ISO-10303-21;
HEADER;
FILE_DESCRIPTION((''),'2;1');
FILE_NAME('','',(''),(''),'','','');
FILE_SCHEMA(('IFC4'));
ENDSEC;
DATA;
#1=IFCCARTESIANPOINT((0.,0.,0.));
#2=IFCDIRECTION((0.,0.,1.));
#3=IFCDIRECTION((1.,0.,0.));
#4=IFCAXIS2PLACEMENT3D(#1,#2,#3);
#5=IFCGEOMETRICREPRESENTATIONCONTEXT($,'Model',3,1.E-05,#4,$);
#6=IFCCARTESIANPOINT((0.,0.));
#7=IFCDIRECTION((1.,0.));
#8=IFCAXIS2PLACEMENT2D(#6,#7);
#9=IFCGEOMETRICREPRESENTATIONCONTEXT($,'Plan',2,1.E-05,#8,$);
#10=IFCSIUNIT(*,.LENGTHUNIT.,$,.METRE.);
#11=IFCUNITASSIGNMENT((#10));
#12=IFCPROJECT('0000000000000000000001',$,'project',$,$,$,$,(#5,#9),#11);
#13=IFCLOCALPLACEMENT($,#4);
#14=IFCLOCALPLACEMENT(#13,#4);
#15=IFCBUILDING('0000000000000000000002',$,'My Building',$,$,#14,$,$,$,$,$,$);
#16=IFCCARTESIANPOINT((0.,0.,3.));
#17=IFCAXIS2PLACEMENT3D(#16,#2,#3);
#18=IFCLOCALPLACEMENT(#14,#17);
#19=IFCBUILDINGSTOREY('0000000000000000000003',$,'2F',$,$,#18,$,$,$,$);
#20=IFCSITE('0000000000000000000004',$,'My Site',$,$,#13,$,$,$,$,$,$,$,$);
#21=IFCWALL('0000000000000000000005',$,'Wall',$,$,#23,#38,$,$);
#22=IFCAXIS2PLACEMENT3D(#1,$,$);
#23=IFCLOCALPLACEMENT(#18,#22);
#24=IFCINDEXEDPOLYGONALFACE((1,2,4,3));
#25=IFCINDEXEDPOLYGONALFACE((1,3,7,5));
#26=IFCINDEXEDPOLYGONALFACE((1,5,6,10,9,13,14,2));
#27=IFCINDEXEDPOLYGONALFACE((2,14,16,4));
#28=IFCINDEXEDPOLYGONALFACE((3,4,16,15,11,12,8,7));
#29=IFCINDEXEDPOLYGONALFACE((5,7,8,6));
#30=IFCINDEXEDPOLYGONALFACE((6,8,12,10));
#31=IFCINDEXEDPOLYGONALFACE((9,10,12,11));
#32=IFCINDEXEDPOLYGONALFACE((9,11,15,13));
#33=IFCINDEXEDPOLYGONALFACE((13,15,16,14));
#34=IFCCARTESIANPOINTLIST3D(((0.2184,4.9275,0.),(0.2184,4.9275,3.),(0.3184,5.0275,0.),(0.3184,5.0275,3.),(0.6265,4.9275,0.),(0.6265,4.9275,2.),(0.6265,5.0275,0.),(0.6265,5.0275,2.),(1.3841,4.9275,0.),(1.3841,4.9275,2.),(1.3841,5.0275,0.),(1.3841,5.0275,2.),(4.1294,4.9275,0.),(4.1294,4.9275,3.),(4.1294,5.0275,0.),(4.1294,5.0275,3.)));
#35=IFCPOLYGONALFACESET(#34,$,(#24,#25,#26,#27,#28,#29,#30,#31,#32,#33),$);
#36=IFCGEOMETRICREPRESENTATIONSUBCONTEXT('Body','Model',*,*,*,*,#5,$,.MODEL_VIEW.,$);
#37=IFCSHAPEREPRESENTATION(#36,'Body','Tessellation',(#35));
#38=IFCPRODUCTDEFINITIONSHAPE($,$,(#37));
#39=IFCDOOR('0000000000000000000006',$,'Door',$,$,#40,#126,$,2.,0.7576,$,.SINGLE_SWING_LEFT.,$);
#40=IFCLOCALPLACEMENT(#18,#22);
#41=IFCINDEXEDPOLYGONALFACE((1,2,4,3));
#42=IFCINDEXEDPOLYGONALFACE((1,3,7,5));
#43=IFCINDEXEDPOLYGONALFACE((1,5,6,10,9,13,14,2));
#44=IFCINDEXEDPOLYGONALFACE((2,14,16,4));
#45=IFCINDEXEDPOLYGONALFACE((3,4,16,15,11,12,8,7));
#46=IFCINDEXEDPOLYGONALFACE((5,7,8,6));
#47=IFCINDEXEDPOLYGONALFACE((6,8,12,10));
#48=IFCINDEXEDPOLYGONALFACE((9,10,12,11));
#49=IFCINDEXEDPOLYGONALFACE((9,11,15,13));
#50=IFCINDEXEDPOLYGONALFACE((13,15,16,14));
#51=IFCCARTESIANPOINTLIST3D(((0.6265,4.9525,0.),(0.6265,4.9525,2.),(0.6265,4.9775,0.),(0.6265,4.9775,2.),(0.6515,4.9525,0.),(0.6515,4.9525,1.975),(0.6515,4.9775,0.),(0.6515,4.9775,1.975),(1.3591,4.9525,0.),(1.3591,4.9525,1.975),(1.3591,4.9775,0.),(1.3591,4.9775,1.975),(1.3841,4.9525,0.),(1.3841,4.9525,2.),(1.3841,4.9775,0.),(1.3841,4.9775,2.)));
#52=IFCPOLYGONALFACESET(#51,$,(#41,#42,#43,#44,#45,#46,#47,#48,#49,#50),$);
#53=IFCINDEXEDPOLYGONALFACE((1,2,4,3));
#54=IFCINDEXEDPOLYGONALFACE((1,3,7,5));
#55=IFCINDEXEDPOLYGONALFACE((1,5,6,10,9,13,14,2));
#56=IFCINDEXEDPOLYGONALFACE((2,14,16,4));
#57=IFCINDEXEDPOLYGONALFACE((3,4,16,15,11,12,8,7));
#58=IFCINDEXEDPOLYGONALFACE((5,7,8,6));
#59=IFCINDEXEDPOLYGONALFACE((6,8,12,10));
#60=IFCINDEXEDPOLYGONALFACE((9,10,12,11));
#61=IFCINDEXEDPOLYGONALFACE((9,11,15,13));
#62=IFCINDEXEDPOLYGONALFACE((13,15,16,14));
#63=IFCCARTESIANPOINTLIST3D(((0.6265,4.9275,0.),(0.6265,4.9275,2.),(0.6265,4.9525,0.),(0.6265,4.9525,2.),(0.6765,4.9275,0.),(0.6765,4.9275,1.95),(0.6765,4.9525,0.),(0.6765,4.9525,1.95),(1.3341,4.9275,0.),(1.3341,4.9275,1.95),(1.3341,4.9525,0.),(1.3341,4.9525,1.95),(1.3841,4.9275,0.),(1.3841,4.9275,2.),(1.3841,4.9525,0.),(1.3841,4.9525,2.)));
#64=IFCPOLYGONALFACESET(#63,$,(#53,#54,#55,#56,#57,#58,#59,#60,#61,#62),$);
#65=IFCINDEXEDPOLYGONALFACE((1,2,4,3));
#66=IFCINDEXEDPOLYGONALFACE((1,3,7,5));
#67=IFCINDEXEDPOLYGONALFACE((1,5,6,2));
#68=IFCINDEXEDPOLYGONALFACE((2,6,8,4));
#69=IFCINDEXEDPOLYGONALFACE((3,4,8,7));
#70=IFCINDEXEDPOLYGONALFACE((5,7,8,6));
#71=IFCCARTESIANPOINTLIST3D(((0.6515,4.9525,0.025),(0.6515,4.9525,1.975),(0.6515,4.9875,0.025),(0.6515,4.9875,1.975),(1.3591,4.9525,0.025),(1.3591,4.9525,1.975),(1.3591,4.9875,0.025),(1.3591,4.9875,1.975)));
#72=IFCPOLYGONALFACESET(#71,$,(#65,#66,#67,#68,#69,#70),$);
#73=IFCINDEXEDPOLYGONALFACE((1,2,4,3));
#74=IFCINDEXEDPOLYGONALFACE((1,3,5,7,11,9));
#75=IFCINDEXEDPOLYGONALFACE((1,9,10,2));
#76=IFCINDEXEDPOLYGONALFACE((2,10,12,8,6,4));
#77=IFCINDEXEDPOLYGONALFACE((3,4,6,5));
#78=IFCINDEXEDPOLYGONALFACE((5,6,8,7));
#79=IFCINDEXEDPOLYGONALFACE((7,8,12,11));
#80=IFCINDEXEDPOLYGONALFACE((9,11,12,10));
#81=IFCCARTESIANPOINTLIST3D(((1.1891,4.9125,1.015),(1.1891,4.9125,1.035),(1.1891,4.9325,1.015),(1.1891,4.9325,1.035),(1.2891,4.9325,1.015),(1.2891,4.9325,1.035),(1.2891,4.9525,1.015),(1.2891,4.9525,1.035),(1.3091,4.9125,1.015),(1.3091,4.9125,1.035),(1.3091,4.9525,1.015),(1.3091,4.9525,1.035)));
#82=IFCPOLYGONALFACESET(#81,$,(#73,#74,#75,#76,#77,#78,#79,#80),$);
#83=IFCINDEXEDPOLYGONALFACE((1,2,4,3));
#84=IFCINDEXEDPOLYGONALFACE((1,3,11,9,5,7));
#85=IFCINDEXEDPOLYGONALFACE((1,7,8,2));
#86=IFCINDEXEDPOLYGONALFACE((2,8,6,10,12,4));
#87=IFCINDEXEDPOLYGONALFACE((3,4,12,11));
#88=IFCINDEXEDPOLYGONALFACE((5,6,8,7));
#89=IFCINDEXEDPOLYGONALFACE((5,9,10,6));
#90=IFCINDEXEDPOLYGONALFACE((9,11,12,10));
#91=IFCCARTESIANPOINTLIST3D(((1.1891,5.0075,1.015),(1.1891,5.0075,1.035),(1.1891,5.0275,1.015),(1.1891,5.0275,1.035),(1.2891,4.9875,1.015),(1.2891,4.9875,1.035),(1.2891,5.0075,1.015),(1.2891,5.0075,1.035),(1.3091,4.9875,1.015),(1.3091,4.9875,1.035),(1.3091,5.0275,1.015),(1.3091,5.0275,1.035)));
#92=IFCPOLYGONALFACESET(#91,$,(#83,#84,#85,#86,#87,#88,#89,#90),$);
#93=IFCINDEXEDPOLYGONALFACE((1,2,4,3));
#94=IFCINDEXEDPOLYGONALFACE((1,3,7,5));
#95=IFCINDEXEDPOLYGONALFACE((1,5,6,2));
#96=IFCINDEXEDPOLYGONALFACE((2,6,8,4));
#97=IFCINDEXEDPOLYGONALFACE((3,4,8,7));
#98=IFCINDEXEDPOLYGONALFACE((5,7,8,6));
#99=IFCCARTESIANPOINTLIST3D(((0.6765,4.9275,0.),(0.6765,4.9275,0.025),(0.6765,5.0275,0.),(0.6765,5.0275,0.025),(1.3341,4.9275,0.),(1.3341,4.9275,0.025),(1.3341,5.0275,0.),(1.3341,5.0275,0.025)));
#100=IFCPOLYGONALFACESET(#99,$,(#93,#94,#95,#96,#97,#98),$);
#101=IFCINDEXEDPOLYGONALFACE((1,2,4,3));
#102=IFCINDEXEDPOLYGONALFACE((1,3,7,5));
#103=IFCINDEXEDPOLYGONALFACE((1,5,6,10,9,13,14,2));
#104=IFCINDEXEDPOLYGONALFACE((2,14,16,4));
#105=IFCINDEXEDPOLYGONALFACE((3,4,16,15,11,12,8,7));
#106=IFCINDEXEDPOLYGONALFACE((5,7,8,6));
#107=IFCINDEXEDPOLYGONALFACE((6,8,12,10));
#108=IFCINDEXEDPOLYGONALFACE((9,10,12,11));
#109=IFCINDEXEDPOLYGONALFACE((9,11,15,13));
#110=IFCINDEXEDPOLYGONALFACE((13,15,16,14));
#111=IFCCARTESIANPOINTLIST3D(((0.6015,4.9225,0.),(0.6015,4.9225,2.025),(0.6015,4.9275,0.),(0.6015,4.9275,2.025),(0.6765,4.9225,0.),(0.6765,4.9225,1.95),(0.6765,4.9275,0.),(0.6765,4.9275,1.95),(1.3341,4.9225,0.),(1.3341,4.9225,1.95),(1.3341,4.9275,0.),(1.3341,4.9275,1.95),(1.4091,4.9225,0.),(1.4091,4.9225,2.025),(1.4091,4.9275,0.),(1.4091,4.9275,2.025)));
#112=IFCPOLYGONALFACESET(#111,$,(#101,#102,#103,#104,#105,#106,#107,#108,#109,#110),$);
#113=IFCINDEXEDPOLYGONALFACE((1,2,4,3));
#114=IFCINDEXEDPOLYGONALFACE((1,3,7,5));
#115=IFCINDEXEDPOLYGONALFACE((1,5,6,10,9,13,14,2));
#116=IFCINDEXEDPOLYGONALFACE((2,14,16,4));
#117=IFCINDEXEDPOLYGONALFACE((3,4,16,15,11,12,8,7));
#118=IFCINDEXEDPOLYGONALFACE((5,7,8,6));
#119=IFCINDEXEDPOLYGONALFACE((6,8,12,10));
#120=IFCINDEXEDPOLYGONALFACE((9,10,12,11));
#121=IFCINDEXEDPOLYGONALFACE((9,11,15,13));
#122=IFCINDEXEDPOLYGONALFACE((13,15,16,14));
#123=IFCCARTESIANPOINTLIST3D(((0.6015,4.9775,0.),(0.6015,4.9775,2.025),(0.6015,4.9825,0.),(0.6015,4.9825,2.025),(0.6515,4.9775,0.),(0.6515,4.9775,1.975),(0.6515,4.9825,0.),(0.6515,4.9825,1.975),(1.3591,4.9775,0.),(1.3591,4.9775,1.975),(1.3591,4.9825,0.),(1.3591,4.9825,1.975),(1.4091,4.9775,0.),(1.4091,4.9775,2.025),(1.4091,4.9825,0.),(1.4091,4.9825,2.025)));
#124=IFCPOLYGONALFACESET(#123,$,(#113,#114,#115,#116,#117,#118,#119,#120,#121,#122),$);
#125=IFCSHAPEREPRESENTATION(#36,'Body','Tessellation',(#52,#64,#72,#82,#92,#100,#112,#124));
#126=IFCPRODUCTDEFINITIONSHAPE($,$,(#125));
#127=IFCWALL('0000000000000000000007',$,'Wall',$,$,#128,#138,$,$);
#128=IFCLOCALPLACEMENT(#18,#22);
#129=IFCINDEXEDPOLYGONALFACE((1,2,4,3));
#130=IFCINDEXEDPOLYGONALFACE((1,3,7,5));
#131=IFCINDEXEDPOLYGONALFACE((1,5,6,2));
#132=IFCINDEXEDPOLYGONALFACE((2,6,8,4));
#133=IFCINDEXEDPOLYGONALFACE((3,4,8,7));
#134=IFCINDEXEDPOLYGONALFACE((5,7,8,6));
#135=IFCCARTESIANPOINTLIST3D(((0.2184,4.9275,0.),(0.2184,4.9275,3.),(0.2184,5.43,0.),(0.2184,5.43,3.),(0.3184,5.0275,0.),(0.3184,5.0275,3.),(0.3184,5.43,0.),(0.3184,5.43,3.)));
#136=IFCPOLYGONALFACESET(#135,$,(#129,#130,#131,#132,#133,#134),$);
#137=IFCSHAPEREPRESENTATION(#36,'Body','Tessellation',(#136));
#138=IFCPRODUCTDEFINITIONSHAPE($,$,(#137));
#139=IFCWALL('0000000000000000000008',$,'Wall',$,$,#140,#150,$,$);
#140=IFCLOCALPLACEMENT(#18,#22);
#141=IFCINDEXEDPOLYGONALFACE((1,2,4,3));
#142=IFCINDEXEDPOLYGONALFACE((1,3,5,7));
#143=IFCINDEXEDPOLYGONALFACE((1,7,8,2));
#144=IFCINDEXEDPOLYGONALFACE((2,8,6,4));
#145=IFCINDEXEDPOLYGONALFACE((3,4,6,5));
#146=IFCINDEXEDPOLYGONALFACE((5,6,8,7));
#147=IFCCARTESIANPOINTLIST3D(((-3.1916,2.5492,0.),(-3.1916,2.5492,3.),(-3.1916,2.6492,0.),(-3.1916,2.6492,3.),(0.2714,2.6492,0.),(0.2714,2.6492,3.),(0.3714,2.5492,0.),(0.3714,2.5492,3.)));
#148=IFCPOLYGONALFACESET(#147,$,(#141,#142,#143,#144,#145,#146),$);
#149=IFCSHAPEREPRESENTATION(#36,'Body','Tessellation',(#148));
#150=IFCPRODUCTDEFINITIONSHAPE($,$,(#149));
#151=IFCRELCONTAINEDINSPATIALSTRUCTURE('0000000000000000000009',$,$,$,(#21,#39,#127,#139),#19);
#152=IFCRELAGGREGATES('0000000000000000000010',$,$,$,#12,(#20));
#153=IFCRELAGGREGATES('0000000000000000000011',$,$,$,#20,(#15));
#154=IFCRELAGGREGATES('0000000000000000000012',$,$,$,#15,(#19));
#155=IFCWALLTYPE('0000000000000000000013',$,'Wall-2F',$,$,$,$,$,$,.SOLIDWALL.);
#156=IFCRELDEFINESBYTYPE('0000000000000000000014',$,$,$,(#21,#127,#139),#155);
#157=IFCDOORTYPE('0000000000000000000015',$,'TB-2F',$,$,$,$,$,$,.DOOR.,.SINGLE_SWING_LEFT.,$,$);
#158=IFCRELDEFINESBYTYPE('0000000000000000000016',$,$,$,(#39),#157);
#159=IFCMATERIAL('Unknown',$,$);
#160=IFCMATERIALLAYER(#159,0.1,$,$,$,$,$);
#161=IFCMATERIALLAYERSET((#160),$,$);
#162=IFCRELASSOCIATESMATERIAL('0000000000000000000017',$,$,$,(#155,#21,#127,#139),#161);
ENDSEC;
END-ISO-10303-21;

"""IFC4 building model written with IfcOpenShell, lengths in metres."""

from ifc_helpers import new_model, entity, si_unit, frame, origin_with_axes, origin_2d_with_axis, place, context, subcontext, project, spatial, line, indexed_curve, outline, extrude, shape, source, transform, mapped, material, layer, layer_set, layer_usage, type_object, type_shapes, element, fill, save


model = new_model("IFC4")

# Units and contexts
model_context = context("Model", 3, precision=1e-05, world=origin_with_axes())
plan_context = context("Plan", 2, precision=1e-05, world=origin_2d_with_axis())
body_context_1 = subcontext(model_context, "Body", "Model", "MODEL_VIEW")
body_context_2 = subcontext(plan_context, "Body", "Plan", "PLAN_VIEW")
ifc_project = project(units=[si_unit("LENGTHUNIT", "METRE")], contexts=[model_context, plan_context])

# Site, building, storey
site_placement = place(None, origin_with_axes())
site = spatial("IfcSite", under=ifc_project, at=site_placement, Name="My Site")
building_placement = place(site_placement, origin_with_axes())
building = spatial("IfcBuilding", under=site, at=building_placement, Name="My Building")
storey_placement = place(building_placement, frame((0.0, 0.0, 3.0), z_axis=(0.0, 0.0, 1.0), x_axis=(1.0, 0.0, 0.0)))
storey = spatial("IfcBuildingStorey", under=building, at=storey_placement, Name="2F")

# Shared definitions
ifc_material = material(Name="Unknown")

# Shared definitions
ifc_layer_1 = layer(ifc_material, 0.1)
ifc_layer_set_1 = layer_set([ifc_layer_1])
wall_type = type_object("IfcWallType", Name="Wall-2F", PredefinedType="SOLIDWALL", material=ifc_layer_set_1)

# Wall, opening, door
ifc_layer_usage_1 = layer_usage(ifc_layer_set_1, "AXIS2", "POSITIVE", 0.0)
wall_1_placement = place(storey_placement, frame((4.2294, 5.0275, 0.0), z_axis=(0.0, 0.0, 1.0), x_axis=(-1.0, 0.0, 0.0)))
wall_1 = element("IfcWall", 1, at=wall_1_placement, inside=storey, type_object=wall_type, material=ifc_layer_usage_1, Name="Wall", context=body_context_1, shape_type="SweptSolid", body=[
    extrude(outline(indexed_curve([(0.1, 0.0), (0.1, 0.1), (4.0111, 0.1), (3.9111, 0.0)], segments=[line(1, 2, 3, 4, 1)])), origin_with_axes(), (0.0, 0.0, 1.0), 3.0),
])
shared_shape_1 = source(origin_with_axes(), body_context_1, "Body", "SweptSolid", [
    extrude(outline(indexed_curve([(0.0, 0.0), (0.7576, 0.0), (0.7576, 2.0), (0.0, 2.0)], segments=[line(1, 2, 3, 4, 1)])), frame((0.0, -0.6, 0.0), z_axis=(0.0, -1.0, 0.0), x_axis=(1.0, 0.0, 0.0)), (0.0, 0.0, -1.0), 1.2),
])
opening_1_placement = place(wall_1_placement, frame((3.6029, 0.1, 0.0), z_axis=(0.0, 0.0, 1.0), x_axis=(-1.0, 0.0, 0.0)))
opening_1 = element("IfcOpeningElement", 2, at=opening_1_placement, cuts=wall_1, PredefinedType="OPENING", context=body_context_1, shape_type="MappedRepresentation", body=[
    mapped(shared_shape_1, transform((0.0, 0.0, 0.0), x_axis=(1.0, 0.0, 0.0), y_axis=(0.0, 1.0, 0.0), z_axis=(0.0, 0.0, 1.0), scale=1.0)),
])
door_type_1 = type_object("IfcDoorType", Name="TB-2F", OperationType="SINGLE_SWING_LEFT", PredefinedType="DOOR")
shared_shape_2 = source(origin_with_axes(), body_context_1, "Body", "SweptSolid", [
    extrude(outline(indexed_curve([(0.0, 0.0), (0.0, 2.0), (0.7576, 2.0), (0.7576, 0.0), (0.7326, 0.0), (0.7326, 1.975), (0.025, 1.975), (0.025, 0.0)], segments=[line(1, 2, 3, 4, 5, 6, 7, 8, 1)])), frame((0.0, 0.025, 0.0), z_axis=(0.0, -1.0, 0.0), x_axis=(1.0, 0.0, 0.0)), (0.0, 0.0, -1.0), 0.025),
    extrude(outline(indexed_curve([(0.0, 0.0), (0.0, 2.0), (0.7576, 2.0), (0.7576, 0.0), (0.7076, 0.0), (0.7076, 1.95), (0.05, 1.95), (0.05, 0.0)], segments=[line(1, 2, 3, 4, 5, 6, 7, 8, 1)])), frame((0.0, 0.0, 0.0), z_axis=(0.0, -1.0, 0.0), x_axis=(1.0, 0.0, 0.0)), (0.0, 0.0, -1.0), 0.025),
    extrude(outline(indexed_curve([(0.0, 0.0), (0.7076, 0.0), (0.7076, 0.035), (0.0, 0.035)], segments=[line(1, 2, 3, 4, 1)])), frame((0.025, 0.025, 0.025), z_axis=(0.0, 0.0, 1.0), x_axis=(1.0, 0.0, 0.0)), (0.0, 0.0, 1.0), 1.95),
    extrude(outline(indexed_curve([(0.0, 0.0), (0.0, -0.04), (-0.12, -0.04), (-0.12, -0.02), (-0.02, -0.02), (-0.02, 0.0)], segments=[line(1, 2, 3, 4, 5, 6, 1)])), frame((0.6826, 0.025, 1.015), z_axis=(0.0, 0.0, 1.0), x_axis=(1.0, 0.0, 0.0)), (0.0, 0.0, 1.0), 0.02),
    extrude(outline(indexed_curve([(0.0, 0.0), (0.0, 0.04), (-0.12, 0.04), (-0.12, 0.02), (-0.02, 0.02), (-0.02, 0.0)], segments=[line(1, 2, 3, 4, 5, 6, 1)])), frame((0.6826, 0.06, 1.015), z_axis=(0.0, 0.0, 1.0), x_axis=(1.0, 0.0, 0.0)), (0.0, 0.0, 1.0), 0.02),
    extrude(outline(indexed_curve([(0.0, 0.0), (0.6576, 0.0), (0.6576, 0.1), (0.0, 0.1)], segments=[line(1, 2, 3, 4, 1)])), frame((0.05, 0.0, 0.0), z_axis=(0.0, 0.0, 1.0), x_axis=(1.0, 0.0, 0.0)), (0.0, 0.0, 1.0), 0.025),
    extrude(outline(indexed_curve([(0.0, 0.0), (0.0, 2.025), (0.8076, 2.025), (0.8076, 0.0), (0.7326, 0.0), (0.7326, 1.95), (0.075, 1.95), (0.075, 0.0)], segments=[line(1, 2, 3, 4, 5, 6, 7, 8, 1)])), frame((-0.025, -0.005, 0.0), z_axis=(0.0, -1.0, 0.0), x_axis=(1.0, 0.0, 0.0)), (0.0, 0.0, -1.0), 0.005),
    extrude(outline(indexed_curve([(0.0, 0.0), (0.0, 2.025), (0.8076, 2.025), (0.8076, 0.0), (0.7576, 0.0), (0.7576, 1.975), (0.05, 1.975), (0.05, 0.0)], segments=[line(1, 2, 3, 4, 5, 6, 7, 8, 1)])), frame((-0.025, 0.05, 0.0), z_axis=(0.0, -1.0, 0.0), x_axis=(1.0, 0.0, 0.0)), (0.0, 0.0, -1.0), 0.005),
])
shared_shape_3 = source(origin_with_axes(), body_context_2, "Body", "Curve2D", [
    entity("IfcIndexedPolyCurve", entity("IfcCartesianPointList2D", [[0.0, 0.0], [0.0, 0.05], [0.025, 0.05], [0.025, 0.025], [0.05, 0.025], [0.05, 0.0]]), [entity("IfcLineIndex", [1, 2, 3, 4, 5, 6, 1])]),
    entity("IfcIndexedPolyCurve", entity("IfcCartesianPointList2D", [[0.7576, 0.0], [0.7576, 0.05], [0.7326, 0.05], [0.7326, 0.025], [0.7076, 0.025], [0.7076, 0.0]]), [entity("IfcLineIndex", [1, 2, 3, 4, 5, 6, 1])]),
    entity("IfcTrimmedCurve", entity("IfcEllipse", entity("IfcAxis2Placement2D", entity("IfcCartesianPoint", [0.06, 0.05]), entity("IfcDirection", [1.0, 0.0])), 0.6726, 0.7076), [entity("IfcCartesianPoint", [0.7326, 0.05])], [entity("IfcCartesianPoint", [0.06, 0.7576])], True, "CARTESIAN"),
    entity("IfcIndexedPolyCurve", entity("IfcCartesianPointList2D", [[0.025, 0.05], [0.06, 0.05], [0.06, 0.7576], [0.025, 0.7576]]), [entity("IfcLineIndex", [1, 2, 3, 4, 1])]),
])
type_shapes(door_type_1, [shared_shape_2, shared_shape_3])
door_1_placement = place(opening_1_placement, frame((0.0, 0.0, 0.0), z_axis=(0.0, 0.0, 1.0), x_axis=(1.0, 0.0, 0.0)))
door_1 = element("IfcDoor", 3, at=door_1_placement, inside=storey, type_object=door_type_1, Name="Door", OperationType="SINGLE_SWING_LEFT", OverallHeight=2.0, OverallWidth=0.7576, shapes=[
    shape(body_context_1, "Body", "MappedRepresentation", [mapped(shared_shape_2, transform((0.0, 0.0, 0.0), x_axis=(1.0, 0.0, 0.0), y_axis=(0.0, 1.0, 0.0), z_axis=(0.0, 0.0, 1.0), scale=1.0))]),
    shape(body_context_2, "Body", "MappedRepresentation", [mapped(shared_shape_3, transform((0.0, 0.0, 0.0), x_axis=(1.0, 0.0, 0.0), y_axis=(0.0, 1.0, 0.0), z_axis=(0.0, 0.0, 1.0), scale=1.0))]),
])
fill(opening_1, door_1)

# Walls
ifc_layer_usage_2 = layer_usage(ifc_layer_set_1, "AXIS2", "NEGATIVE", 0.0)
wall_2_placement = place(storey_placement, frame((0.3184, 5.43, 0.0), z_axis=(0.0, 0.0, 1.0), x_axis=(0.0, -1.0, 0.0)))
element("IfcWall", 4, at=wall_2_placement, inside=storey, type_object=wall_type, material=ifc_layer_usage_2, Name="Wall", context=body_context_1, shape_type="SweptSolid", body=[
    extrude(outline(indexed_curve([(0.0, -0.1), (0.0, 0.0), (0.4025, 0.0), (0.5025, -0.1)], segments=[line(1, 2, 3, 4, 1)])), origin_with_axes(), (0.0, 0.0, 1.0), 3.0),
])
ifc_layer_usage_3 = layer_usage(ifc_layer_set_1, "AXIS2", "POSITIVE", 0.0)
wall_3_placement = place(storey_placement, frame((-3.1916, 2.5492, 0.0), z_axis=(0.0, 0.0, 1.0), x_axis=(1.0, 0.0, 0.0)))
element("IfcWall", 5, at=wall_3_placement, inside=storey, type_object=wall_type, material=ifc_layer_usage_3, Name="Wall", context=body_context_1, shape_type="SweptSolid", body=[
    extrude(outline(indexed_curve([(0.0, 0.0), (0.0, 0.1), (3.463, 0.1), (3.563, 0.0)], segments=[line(1, 2, 3, 4, 1)])), origin_with_axes(), (0.0, 0.0, 1.0), 3.0),
])

save(model, "model.ifc")
